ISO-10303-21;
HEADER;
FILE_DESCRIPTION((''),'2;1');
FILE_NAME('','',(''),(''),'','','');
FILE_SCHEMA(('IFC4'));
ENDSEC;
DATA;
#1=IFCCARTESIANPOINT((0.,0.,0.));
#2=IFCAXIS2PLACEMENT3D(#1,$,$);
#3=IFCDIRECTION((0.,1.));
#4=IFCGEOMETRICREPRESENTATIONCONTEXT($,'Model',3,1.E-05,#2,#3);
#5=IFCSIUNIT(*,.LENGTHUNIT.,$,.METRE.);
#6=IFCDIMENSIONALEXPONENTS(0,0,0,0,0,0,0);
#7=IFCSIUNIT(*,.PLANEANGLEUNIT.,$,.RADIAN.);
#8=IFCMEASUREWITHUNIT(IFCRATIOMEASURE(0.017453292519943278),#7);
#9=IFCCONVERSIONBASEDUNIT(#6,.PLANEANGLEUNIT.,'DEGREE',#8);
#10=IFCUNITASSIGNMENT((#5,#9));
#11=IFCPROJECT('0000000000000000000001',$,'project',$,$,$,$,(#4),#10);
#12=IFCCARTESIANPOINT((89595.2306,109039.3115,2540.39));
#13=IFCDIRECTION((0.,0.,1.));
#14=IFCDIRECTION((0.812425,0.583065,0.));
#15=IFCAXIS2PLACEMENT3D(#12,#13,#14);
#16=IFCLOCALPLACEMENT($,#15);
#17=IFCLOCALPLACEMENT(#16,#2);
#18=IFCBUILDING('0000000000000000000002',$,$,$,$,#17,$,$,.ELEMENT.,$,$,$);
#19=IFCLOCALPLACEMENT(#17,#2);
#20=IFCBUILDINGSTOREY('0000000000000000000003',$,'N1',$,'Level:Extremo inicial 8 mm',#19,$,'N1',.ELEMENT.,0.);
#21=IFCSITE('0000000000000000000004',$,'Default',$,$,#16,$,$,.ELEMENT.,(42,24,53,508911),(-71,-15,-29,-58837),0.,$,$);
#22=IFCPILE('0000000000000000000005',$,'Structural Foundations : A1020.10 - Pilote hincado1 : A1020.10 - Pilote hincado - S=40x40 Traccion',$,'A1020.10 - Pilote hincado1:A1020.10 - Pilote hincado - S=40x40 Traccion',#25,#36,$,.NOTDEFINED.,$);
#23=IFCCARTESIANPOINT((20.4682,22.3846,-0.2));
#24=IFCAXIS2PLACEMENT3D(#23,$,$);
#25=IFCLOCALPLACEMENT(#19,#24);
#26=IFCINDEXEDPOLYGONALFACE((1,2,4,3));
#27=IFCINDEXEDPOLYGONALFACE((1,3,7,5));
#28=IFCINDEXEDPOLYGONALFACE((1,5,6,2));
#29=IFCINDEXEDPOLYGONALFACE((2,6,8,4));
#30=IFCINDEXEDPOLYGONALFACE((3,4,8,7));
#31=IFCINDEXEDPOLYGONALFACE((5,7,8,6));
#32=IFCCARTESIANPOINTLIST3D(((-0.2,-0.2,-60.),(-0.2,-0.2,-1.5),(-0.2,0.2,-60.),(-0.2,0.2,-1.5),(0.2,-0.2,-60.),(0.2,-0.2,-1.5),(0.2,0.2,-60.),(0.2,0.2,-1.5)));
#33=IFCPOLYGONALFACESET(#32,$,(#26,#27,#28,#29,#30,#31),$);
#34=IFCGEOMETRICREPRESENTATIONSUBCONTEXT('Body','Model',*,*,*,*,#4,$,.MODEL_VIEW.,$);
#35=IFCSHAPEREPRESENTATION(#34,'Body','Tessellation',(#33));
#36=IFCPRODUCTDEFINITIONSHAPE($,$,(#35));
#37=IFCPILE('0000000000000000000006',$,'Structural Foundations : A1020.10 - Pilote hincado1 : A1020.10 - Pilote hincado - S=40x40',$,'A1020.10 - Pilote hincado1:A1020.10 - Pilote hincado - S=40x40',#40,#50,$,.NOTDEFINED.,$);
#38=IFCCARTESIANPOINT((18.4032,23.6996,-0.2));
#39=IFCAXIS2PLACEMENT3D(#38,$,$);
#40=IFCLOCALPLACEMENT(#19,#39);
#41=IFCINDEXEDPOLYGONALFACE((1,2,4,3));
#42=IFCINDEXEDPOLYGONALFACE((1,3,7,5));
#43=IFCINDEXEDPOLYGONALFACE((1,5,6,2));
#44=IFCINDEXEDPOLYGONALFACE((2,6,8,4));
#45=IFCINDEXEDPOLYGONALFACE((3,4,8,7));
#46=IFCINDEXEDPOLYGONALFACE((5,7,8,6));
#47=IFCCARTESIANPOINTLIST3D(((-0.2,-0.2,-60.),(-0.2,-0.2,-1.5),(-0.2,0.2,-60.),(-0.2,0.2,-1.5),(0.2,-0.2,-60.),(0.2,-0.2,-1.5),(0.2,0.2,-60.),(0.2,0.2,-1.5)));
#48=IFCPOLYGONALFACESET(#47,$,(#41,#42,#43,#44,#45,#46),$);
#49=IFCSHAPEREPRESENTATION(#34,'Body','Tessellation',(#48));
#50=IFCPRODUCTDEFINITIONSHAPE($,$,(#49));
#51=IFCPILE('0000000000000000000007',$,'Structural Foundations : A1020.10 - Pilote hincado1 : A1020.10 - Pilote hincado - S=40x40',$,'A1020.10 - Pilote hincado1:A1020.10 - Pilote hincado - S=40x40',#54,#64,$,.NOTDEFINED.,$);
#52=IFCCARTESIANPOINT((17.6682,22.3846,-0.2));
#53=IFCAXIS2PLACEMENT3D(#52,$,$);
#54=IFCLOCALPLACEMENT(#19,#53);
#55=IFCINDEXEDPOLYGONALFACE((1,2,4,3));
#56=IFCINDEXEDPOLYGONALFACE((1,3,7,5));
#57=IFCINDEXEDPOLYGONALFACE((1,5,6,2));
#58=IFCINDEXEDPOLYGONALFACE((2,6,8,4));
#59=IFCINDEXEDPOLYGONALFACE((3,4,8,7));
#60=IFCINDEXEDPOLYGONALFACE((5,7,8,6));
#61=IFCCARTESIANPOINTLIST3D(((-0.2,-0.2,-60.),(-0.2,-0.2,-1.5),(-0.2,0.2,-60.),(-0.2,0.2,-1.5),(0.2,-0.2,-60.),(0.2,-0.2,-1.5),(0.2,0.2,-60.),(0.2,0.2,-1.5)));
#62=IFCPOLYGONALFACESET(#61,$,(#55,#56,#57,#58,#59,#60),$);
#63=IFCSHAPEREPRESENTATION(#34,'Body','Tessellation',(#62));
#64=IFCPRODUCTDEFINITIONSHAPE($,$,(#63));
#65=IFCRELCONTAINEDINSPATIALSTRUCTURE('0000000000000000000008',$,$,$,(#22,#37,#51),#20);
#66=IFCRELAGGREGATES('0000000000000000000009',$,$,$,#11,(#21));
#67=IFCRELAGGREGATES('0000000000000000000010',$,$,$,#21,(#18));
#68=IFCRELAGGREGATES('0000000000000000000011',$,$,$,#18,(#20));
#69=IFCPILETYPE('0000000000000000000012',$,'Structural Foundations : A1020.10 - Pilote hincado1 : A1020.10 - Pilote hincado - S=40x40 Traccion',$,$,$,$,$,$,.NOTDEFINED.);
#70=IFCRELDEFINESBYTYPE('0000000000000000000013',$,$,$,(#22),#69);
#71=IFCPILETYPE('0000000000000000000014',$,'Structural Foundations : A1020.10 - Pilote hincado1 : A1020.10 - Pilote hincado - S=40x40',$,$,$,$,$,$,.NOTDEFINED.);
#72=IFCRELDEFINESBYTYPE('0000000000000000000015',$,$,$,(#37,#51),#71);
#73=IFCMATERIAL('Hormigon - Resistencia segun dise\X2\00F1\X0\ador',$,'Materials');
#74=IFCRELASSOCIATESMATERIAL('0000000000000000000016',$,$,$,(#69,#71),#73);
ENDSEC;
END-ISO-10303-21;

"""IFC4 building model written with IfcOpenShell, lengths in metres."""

from ifc_helpers import new_model, entity, si_unit, converted_unit, direction, frame, origin, origin_2d_with_axis, place, context, subcontext, project, spatial, polyline, segment, composite_curve, rectangle, outline, extrude, source, transform, mapped, material, material_profile, profile_set, type_object, type_shapes, element, save


model = new_model("IFC4")

# Units and contexts
model_context = context("Model", 3, precision=1e-05, world=origin(), true_north=direction((0.0, 1.0)))
body_context = subcontext(model_context, "Body", "Model", "MODEL_VIEW")
ifc_project = project(units=[si_unit("LENGTHUNIT", "METRE"), converted_unit("PLANEANGLEUNIT", "DEGREE", entity("IfcRatioMeasure", 0.017453292519943278), si_unit("PLANEANGLEUNIT", "RADIAN"), dimensions=[0, 0, 0, 0, 0, 0, 0])], contexts=[model_context])

# Site, building, storey
site_placement = place(None, frame((89595.2306, 109039.3115, 2540.39), z_axis=(0.0, 0.0, 1.0), x_axis=(0.812425, 0.583065, 0.0)))
site = spatial("IfcSite", under=ifc_project, at=site_placement, Name="Default", CompositionType="ELEMENT", RefLatitude=(42, 24, 53, 508911), RefLongitude=(-71, -15, -29, -58837), RefElevation=0.0)
building_placement = place(site_placement, origin())
building = spatial("IfcBuilding", under=site, at=building_placement, CompositionType="ELEMENT")
storey_placement = place(building_placement, origin())
storey = spatial("IfcBuildingStorey", under=building, at=storey_placement, Name="N1", ObjectType="Level:Extremo inicial 8 mm", LongName="N1", CompositionType="ELEMENT", Elevation=0.0)

# Piles
ifc_material_1 = material(Name="Hormigon - Resistencia segun diseñador", Category="Materials")
ifc_material_profile_1 = material_profile(ifc_material_1, outline(composite_curve([segment(polyline([(0.2, -0.2, -1.5), (0.2, 0.2, -1.5)]), True, "CONTINUOUS"), segment(polyline([(0.2, 0.2, -1.5), (-0.2, 0.2, -1.5)]), True, "CONTINUOUS"), segment(polyline([(-0.2, 0.2, -1.5), (-0.2, -0.2, -1.5)]), True, "CONTINUOUS"), segment(polyline([(-0.2, -0.2, -1.5), (0.2, -0.2, -1.5)]), True, "CONTINUOUS")], self_intersect=False), kind="CURVE"), Name="A1020.10 - Pilote hincado - S=40x40 Traccion")
ifc_profile_set_1 = profile_set([ifc_material_profile_1], Name="A1020.10 - Pilote hincado - S=40x40 Traccion")
pile_type_1 = type_object("IfcPileType", Name="Structural Foundations : A1020.10 - Pilote hincado1 : A1020.10 - Pilote hincado - S=40x40 Traccion", PredefinedType="NOTDEFINED", material=ifc_profile_set_1)
shared_shape_1 = source(origin(), body_context, "Body", "SweptSolid", [
    extrude(rectangle(XDim=0.4, YDim=0.4, at=origin_2d_with_axis()), frame((0.0, 0.0, -60.0), z_axis=(0.0, 0.0, 1.0), x_axis=(0.0, -1.0, 0.0)), (0.0, 0.0, 1.0), 58.5),
])
type_shapes(pile_type_1, [shared_shape_1])
for number, where, name in (
    (1, (20.4682, 22.3846, -0.2), "Structural Foundations : A1020.10 - Pilote hincado1 : A1020.10 - Pilote hincado - S=40x40 Traccion"),
):
    element("IfcPile", number, at=place(storey_placement, frame(where)), inside=storey, type_object=pile_type_1, Name=name, ObjectType="A1020.10 - Pilote hincado1:A1020.10 - Pilote hincado - S=40x40 Traccion", PredefinedType="NOTDEFINED", context=body_context, shape_type="MappedRepresentation", body=[
        mapped(shared_shape_1, transform((0.0, 0.0, 0.0), scale=1.0)),
    ])
ifc_material_profile_2 = material_profile(ifc_material_1, outline(composite_curve([segment(polyline([(0.2, -0.2, -60.0), (-0.2, -0.2, -60.0)]), True, "CONTINUOUS"), segment(polyline([(-0.2, -0.2, -60.0), (-0.2, 0.2, -60.0)]), True, "CONTINUOUS"), segment(polyline([(-0.2, 0.2, -60.0), (0.2, 0.2, -60.0)]), True, "CONTINUOUS"), segment(polyline([(0.2, 0.2, -60.0), (0.2, -0.2, -60.0)]), True, "CONTINUOUS")], self_intersect=False), kind="CURVE"), Name="A1020.10 - Pilote hincado - S=40x40")
ifc_profile_set_2 = profile_set([ifc_material_profile_2], Name="A1020.10 - Pilote hincado - S=40x40")
pile_type_2 = type_object("IfcPileType", Name="Structural Foundations : A1020.10 - Pilote hincado1 : A1020.10 - Pilote hincado - S=40x40", PredefinedType="NOTDEFINED", material=ifc_profile_set_2)
shared_shape_2 = source(origin(), body_context, "Body", "SweptSolid", [
    extrude(rectangle(XDim=0.4, YDim=0.4, at=origin_2d_with_axis()), frame((0.0, 0.0, -60.0), z_axis=(0.0, 0.0, 1.0), x_axis=(0.0, -1.0, 0.0)), (0.0, 0.0, 1.0), 58.5),
])
type_shapes(pile_type_2, [shared_shape_2])
for number, where, name in (
    (2, (18.4032, 23.6996, -0.2), "Structural Foundations : A1020.10 - Pilote hincado1 : A1020.10 - Pilote hincado - S=40x40"),
    (3, (17.6682, 22.3846, -0.2), "Structural Foundations : A1020.10 - Pilote hincado1 : A1020.10 - Pilote hincado - S=40x40"),
):
    element("IfcPile", number, at=place(storey_placement, frame(where)), inside=storey, type_object=pile_type_2, Name=name, ObjectType="A1020.10 - Pilote hincado1:A1020.10 - Pilote hincado - S=40x40", PredefinedType="NOTDEFINED", context=body_context, shape_type="MappedRepresentation", body=[
        mapped(shared_shape_2, transform((0.0, 0.0, 0.0), scale=1.0)),
    ])

save(model, "model.ifc")
